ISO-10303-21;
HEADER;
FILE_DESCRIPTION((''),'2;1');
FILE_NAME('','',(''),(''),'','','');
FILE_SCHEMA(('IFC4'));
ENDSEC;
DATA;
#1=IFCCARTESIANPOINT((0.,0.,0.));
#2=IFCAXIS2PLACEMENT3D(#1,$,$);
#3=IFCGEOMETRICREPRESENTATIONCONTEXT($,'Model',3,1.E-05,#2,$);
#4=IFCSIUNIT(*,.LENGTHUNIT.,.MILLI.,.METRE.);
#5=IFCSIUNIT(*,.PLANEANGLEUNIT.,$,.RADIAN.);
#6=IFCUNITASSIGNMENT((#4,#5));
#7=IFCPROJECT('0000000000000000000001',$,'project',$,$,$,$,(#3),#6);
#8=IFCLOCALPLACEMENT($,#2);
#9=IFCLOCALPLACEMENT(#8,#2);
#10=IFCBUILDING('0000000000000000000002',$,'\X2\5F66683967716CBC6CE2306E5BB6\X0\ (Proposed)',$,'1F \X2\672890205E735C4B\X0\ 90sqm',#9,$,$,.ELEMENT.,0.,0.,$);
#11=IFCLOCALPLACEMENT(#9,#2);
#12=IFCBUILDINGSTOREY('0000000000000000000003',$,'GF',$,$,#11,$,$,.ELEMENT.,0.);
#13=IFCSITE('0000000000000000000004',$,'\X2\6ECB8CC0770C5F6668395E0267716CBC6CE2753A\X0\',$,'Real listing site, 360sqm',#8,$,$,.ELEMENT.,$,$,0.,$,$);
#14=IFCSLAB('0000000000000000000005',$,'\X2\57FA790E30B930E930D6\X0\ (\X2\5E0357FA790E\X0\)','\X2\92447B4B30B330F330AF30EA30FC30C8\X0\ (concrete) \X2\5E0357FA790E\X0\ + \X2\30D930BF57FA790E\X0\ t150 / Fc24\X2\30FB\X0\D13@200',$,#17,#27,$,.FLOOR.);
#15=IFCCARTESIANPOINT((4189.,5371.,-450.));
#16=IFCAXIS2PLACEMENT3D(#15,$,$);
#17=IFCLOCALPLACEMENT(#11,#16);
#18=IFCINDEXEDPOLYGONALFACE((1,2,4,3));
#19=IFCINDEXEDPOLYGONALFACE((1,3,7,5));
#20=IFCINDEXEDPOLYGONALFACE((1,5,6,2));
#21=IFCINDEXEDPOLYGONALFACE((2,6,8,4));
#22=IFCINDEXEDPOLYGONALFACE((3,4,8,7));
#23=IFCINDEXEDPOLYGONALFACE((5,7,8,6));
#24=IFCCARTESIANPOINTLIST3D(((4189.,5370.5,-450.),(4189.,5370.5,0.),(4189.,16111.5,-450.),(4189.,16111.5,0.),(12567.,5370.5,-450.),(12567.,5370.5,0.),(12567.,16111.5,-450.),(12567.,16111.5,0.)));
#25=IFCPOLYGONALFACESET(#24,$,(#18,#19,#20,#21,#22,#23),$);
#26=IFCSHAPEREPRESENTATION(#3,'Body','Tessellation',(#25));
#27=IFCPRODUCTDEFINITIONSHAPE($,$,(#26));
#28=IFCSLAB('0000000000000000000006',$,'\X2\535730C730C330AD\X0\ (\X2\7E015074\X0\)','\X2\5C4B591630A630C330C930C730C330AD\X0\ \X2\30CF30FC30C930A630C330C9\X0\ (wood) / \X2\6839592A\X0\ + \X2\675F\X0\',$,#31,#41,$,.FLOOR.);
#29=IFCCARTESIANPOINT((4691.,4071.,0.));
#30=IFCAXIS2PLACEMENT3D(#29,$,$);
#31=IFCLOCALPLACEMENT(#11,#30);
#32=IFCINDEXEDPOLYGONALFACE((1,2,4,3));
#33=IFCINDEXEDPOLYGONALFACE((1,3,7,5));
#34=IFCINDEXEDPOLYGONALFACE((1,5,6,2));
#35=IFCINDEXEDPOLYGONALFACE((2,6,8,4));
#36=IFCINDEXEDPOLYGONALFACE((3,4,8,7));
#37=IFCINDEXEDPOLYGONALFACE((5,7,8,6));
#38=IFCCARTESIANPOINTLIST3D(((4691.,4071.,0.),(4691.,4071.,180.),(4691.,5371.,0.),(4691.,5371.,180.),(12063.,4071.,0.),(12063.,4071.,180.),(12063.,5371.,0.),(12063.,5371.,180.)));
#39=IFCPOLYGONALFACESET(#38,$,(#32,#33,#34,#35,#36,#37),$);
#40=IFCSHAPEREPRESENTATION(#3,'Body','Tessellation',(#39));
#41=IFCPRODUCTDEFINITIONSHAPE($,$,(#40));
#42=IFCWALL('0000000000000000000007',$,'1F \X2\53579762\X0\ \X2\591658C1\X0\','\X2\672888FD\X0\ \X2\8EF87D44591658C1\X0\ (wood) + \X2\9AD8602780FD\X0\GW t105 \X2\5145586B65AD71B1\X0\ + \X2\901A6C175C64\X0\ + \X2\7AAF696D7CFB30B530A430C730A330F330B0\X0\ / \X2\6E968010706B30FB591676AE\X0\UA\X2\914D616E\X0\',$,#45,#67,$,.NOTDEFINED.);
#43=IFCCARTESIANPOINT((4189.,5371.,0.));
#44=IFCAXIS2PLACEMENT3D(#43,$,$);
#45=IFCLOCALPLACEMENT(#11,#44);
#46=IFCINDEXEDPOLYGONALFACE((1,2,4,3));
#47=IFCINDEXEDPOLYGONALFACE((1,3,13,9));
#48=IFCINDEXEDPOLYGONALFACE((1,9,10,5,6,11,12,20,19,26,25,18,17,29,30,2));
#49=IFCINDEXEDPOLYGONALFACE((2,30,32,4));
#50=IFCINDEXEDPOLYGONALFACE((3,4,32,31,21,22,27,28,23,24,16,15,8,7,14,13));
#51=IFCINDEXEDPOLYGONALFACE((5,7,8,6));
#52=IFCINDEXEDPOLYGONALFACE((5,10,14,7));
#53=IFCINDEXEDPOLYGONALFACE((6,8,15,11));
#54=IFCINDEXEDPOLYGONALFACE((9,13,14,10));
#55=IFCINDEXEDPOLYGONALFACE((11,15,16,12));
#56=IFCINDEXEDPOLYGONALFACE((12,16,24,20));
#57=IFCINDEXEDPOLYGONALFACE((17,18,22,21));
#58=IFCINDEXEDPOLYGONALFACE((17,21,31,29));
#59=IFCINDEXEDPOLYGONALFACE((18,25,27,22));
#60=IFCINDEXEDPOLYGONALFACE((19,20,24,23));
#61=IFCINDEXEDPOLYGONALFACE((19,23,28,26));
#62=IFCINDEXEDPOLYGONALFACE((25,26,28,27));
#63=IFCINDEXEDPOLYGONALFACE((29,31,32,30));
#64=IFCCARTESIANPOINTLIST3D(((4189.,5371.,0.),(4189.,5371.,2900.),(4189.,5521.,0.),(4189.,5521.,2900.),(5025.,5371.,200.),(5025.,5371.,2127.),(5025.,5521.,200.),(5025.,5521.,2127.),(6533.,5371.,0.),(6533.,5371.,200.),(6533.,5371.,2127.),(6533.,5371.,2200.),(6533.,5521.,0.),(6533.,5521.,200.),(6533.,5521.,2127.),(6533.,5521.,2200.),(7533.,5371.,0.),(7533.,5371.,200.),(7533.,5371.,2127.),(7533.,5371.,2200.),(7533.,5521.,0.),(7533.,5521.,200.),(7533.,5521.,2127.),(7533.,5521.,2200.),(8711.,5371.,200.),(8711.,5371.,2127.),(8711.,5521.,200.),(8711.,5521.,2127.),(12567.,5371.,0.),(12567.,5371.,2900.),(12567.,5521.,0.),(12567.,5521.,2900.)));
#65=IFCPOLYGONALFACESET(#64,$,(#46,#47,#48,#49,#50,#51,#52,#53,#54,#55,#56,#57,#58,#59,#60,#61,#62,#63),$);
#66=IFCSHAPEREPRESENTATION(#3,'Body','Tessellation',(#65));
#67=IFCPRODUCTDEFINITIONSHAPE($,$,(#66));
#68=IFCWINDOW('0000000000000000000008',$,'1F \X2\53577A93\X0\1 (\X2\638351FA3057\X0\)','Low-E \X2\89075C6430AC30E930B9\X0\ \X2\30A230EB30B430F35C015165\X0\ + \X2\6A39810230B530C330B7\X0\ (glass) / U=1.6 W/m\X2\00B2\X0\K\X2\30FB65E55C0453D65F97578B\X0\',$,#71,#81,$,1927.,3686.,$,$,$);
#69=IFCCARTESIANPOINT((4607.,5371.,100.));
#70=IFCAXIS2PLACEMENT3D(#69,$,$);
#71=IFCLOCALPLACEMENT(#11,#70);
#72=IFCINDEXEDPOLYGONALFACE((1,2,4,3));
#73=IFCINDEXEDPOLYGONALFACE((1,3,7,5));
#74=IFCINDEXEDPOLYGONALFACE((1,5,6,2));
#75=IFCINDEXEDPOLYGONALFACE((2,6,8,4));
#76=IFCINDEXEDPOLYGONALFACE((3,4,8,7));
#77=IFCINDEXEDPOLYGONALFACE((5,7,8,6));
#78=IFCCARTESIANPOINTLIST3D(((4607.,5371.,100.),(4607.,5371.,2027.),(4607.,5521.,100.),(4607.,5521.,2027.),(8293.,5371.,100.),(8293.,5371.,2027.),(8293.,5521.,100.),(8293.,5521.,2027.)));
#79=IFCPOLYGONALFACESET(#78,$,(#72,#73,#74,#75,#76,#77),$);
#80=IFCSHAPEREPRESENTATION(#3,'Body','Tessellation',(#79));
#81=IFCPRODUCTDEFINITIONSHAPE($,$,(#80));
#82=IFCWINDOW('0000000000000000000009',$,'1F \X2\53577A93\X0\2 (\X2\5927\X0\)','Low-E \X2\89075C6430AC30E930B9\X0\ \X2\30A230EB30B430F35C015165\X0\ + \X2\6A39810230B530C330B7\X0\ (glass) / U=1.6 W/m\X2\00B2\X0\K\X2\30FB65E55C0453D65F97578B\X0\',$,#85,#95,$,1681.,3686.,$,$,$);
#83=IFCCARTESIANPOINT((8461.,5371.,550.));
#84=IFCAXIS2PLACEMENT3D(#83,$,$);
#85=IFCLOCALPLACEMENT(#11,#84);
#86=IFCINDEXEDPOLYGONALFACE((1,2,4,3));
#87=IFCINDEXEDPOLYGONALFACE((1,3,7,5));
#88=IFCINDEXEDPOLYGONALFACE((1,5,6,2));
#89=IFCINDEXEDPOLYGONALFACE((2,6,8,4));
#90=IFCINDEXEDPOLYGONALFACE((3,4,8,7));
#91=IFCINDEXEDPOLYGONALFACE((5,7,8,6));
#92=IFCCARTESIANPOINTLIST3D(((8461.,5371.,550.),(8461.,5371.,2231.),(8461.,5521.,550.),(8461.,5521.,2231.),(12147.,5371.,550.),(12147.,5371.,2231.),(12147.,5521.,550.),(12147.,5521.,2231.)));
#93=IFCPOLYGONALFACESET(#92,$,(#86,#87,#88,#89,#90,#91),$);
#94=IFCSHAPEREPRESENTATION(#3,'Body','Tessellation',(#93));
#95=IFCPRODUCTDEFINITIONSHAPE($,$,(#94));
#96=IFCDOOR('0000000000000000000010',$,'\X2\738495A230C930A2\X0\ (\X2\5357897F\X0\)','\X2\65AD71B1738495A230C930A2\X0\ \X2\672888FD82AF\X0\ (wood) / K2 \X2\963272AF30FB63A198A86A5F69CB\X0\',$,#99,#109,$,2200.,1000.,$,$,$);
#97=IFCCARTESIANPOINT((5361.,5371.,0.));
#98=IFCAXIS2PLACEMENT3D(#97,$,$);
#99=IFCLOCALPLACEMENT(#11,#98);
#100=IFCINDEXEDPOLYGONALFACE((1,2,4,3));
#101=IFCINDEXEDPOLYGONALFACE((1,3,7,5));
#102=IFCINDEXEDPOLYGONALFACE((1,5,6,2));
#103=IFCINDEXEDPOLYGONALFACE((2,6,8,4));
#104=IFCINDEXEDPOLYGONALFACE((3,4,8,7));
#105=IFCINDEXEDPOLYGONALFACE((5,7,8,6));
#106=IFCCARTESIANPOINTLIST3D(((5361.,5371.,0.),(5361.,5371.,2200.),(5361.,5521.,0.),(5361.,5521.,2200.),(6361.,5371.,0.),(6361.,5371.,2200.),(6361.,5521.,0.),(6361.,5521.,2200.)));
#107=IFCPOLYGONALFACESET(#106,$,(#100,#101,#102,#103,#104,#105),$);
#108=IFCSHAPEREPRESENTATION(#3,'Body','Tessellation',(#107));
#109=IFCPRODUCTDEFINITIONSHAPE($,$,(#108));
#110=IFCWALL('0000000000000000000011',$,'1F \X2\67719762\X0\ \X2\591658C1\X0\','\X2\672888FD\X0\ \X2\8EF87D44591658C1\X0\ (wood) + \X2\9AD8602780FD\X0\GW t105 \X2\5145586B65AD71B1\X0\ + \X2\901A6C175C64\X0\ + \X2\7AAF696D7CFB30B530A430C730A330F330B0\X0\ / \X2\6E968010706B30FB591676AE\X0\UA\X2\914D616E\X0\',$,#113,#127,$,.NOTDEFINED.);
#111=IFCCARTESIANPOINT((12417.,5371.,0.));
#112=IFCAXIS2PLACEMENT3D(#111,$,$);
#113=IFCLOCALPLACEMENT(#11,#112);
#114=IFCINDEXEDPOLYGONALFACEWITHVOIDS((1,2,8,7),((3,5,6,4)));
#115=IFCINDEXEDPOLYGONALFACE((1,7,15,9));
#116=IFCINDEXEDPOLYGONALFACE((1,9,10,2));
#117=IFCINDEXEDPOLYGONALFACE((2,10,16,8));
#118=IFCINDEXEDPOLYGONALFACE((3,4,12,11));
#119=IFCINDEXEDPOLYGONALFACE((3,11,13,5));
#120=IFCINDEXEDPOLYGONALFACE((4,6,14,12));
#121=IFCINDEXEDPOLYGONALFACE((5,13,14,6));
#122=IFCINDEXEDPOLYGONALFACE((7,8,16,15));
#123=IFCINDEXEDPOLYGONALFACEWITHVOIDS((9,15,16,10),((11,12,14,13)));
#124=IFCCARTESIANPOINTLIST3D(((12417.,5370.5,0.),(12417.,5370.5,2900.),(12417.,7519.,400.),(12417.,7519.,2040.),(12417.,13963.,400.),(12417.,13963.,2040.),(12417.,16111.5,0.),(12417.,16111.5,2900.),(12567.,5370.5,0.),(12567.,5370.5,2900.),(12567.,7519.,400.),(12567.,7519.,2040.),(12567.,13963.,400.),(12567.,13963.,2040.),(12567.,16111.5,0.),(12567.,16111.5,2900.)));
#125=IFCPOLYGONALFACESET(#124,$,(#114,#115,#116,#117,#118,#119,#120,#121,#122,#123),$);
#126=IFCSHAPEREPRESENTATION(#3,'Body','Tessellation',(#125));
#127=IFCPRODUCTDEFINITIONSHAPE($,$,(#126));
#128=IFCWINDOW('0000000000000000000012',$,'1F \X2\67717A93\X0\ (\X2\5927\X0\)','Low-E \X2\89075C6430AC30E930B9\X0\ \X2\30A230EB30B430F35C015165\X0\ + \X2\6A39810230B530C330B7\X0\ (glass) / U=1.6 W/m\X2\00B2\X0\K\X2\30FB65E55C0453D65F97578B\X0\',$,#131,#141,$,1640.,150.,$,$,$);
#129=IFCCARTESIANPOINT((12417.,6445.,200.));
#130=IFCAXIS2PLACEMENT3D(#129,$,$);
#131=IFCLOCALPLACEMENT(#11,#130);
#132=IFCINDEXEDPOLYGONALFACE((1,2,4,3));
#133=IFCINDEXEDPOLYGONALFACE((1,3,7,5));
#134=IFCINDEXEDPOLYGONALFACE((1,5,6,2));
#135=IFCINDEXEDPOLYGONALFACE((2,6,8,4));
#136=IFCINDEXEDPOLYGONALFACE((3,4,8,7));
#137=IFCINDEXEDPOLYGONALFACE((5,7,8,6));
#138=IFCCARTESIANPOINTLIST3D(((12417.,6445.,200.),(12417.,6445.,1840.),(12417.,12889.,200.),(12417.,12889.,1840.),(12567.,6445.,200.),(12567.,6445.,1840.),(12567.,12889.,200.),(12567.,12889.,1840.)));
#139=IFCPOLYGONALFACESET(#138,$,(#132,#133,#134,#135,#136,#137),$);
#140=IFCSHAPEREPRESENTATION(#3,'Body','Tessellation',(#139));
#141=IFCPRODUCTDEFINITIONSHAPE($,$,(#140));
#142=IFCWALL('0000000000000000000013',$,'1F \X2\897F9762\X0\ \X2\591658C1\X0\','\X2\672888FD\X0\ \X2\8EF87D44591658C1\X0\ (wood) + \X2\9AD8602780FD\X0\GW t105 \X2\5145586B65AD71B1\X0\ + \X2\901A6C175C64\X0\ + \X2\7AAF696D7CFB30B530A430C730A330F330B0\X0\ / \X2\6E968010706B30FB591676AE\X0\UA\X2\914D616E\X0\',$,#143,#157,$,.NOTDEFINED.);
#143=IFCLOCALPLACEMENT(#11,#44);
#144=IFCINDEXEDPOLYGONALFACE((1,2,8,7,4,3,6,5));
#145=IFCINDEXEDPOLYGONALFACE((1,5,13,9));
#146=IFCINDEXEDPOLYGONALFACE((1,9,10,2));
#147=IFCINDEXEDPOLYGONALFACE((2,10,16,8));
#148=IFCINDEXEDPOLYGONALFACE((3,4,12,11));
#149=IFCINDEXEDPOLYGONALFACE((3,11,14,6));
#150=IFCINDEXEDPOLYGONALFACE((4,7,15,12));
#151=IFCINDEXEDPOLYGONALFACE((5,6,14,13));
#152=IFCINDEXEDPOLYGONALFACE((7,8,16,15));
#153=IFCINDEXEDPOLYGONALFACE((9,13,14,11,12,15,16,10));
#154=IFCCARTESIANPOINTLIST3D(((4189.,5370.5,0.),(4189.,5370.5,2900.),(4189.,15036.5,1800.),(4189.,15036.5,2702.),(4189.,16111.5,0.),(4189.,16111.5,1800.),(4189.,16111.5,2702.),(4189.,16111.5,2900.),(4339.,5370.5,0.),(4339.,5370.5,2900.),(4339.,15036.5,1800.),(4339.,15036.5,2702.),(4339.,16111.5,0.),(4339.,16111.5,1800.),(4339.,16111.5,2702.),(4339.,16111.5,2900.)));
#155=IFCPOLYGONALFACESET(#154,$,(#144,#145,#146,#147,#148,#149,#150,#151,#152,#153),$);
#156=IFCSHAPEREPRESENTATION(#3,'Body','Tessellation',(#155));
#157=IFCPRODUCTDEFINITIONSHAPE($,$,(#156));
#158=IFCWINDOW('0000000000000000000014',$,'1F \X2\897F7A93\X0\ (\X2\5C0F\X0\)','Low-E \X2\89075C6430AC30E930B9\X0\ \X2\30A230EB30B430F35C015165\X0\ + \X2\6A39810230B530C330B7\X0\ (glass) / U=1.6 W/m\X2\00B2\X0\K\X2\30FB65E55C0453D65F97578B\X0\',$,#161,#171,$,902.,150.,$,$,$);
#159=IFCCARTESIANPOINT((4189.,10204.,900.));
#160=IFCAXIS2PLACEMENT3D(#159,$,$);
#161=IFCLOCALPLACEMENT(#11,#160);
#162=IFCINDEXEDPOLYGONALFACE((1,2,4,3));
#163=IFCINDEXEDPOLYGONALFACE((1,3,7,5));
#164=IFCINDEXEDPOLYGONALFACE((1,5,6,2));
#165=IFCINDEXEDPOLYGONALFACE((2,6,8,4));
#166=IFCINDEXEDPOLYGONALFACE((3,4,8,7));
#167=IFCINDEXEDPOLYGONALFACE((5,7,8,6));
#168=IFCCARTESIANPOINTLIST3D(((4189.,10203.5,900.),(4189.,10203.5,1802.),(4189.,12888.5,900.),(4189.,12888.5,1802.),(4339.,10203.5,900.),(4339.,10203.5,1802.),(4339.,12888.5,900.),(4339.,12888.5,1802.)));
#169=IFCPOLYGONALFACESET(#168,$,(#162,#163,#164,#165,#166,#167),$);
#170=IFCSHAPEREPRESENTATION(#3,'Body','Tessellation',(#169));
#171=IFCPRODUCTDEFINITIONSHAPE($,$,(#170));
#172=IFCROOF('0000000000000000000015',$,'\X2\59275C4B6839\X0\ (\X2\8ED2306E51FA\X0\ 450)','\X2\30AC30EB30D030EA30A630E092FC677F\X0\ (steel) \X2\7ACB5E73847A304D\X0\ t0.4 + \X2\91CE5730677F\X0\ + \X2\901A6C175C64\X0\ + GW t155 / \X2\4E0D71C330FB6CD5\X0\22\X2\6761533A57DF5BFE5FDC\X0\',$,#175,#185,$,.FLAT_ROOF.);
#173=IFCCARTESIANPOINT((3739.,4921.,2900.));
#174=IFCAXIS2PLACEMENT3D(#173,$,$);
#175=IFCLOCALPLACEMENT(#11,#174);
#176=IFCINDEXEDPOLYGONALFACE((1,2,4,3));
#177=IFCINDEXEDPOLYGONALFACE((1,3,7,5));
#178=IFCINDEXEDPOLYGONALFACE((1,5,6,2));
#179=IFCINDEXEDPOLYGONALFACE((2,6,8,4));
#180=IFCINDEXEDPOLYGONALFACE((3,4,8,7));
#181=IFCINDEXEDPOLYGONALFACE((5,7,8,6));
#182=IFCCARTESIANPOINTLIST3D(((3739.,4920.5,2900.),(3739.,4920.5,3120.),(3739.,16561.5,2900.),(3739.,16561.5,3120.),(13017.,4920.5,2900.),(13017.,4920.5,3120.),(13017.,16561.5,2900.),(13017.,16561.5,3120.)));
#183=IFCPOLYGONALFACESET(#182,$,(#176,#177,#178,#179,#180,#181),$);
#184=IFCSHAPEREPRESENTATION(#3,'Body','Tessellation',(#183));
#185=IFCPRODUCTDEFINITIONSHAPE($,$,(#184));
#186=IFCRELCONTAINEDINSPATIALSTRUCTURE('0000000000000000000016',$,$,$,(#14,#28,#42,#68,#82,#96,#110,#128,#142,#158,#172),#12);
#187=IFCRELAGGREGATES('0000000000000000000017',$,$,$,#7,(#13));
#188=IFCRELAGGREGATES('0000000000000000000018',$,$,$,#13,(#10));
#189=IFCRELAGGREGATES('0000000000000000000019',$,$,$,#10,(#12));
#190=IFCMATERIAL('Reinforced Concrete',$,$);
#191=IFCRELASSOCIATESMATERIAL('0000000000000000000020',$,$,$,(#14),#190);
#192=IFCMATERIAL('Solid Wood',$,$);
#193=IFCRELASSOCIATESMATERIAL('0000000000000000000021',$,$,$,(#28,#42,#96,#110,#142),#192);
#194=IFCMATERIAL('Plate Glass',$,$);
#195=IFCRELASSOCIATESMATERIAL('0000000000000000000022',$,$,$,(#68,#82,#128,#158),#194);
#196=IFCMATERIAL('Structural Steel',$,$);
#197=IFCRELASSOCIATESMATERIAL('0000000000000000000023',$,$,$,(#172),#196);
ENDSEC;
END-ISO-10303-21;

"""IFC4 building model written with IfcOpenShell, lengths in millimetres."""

from ifc_helpers import new_model, si_unit, frame, frame_2d, origin, place, context, project, spatial, rectangle, extrude, material, element, fill, save


model = new_model("IFC4")

# Units and contexts
model_context = context("Model", 3, precision=1e-05, world=origin())
ifc_project = project(units=[si_unit("LENGTHUNIT", "METRE", prefix="MILLI"), si_unit("PLANEANGLEUNIT", "RADIAN")], contexts=[model_context])

# Site, building, storey
site_placement = place(None, origin())
site = spatial("IfcSite", under=ifc_project, at=site_placement, Name="滋賀県彦根市東沼波町", ObjectType="Real listing site, 360sqm", CompositionType="ELEMENT", RefElevation=0.0)
building_placement = place(site_placement, origin())
building = spatial("IfcBuilding", under=site, at=building_placement, Name="彦根東沼波の家 (Proposed)", ObjectType="1F 木造平屋 90sqm", CompositionType="ELEMENT", ElevationOfRefHeight=0.0, ElevationOfTerrain=0.0)
storey_placement = place(building_placement, origin())
storey = spatial("IfcBuildingStorey", under=building, at=storey_placement, Name="GF", CompositionType="ELEMENT", Elevation=0.0)

# Slabs
ifc_material_1 = material(Name="Reinforced Concrete")
slab_1_placement = place(storey_placement, frame((4189.0, 5371.0, -450.0)))
element("IfcSlab", 1, at=slab_1_placement, inside=storey, material=ifc_material_1, Name="基礎スラブ (布基礎)", Description="鉄筋コンクリート (concrete) 布基礎 + ベタ基礎 t150 / Fc24・D13@200", PredefinedType="FLOOR", context=model_context, shape_type="SweptSolid", body=[
    extrude(rectangle(XDim=8378.0, YDim=10741.0, at=frame_2d((4189.0, 5370.0))), frame((4189.0, 5371.0, -450.0)), (0.0, 0.0, 1.0), 450.0),
])
ifc_material_2 = material(Name="Solid Wood")
slab_2_placement = place(storey_placement, frame((4691.0, 4071.0, 0.0)))
element("IfcSlab", 2, at=slab_2_placement, inside=storey, material=ifc_material_2, Name="南デッキ (縁側)", Description="屋外ウッドデッキ ハードウッド (wood) / 根太 + 束", PredefinedType="FLOOR", context=model_context, shape_type="SweptSolid", body=[
    extrude(rectangle(XDim=7372.0, YDim=1300.0, at=frame_2d((3686.0, 650.0))), frame((4691.0, 4071.0, 0.0)), (0.0, 0.0, 1.0), 180.0),
])

# Wall, openings, windows, door
wall_1_placement = place(storey_placement, frame((4189.0, 5371.0, 0.0)))
wall_1 = element("IfcWall", 3, at=wall_1_placement, inside=storey, material=ifc_material_2, Name="1F 南面 外壁", Description="木製 軸組外壁 (wood) + 高性能GW t105 充填断熱 + 通気層 + 窯業系サイディング / 準耐火・外皮UA配慮", PredefinedType="NOTDEFINED", context=model_context, shape_type="SweptSolid", body=[
    extrude(rectangle(XDim=8378.0, YDim=150.0, at=frame_2d((4189.0, 75.0))), frame((4189.0, 5371.0, 0.0)), (0.0, 0.0, 1.0), 2900.0),
])
opening_1_placement = place(storey_placement, frame((4607.0, 5371.0, 100.0)))
opening_1 = element("IfcOpeningElement", 4, at=opening_1_placement, cuts=wall_1, PredefinedType="NOTDEFINED", context=model_context, shape_type="SweptSolid", body=[
    extrude(rectangle(XDim=3686.0, YDim=150.0, at=frame_2d((1843.0, 75.0))), frame((4607.0, 5371.0, 100.0)), (0.0, 0.0, 1.0), 1927.0),
])
opening_2_placement = place(storey_placement, frame((8461.0, 5371.0, 550.0)))
opening_2 = element("IfcOpeningElement", 5, at=opening_2_placement, cuts=wall_1, PredefinedType="NOTDEFINED", context=model_context, shape_type="SweptSolid", body=[
    extrude(rectangle(XDim=3686.0, YDim=150.0, at=frame_2d((1843.0, 75.0))), frame((8461.0, 5371.0, 550.0)), (0.0, 0.0, 1.0), 1681.0),
])
opening_3_placement = place(storey_placement, frame((5361.0, 5371.0, 0.0)))
opening_3 = element("IfcOpeningElement", 6, at=opening_3_placement, cuts=wall_1, PredefinedType="NOTDEFINED", context=model_context, shape_type="SweptSolid", body=[
    extrude(rectangle(XDim=1000.0, YDim=150.0, at=frame_2d((500.0, 75.0))), frame((5361.0, 5371.0, 0.0)), (0.0, 0.0, 1.0), 2200.0),
])
ifc_material_3 = material(Name="Plate Glass")
window_1_placement = place(storey_placement, frame((4607.0, 5371.0, 100.0)))
window_1 = element("IfcWindow", 7, at=window_1_placement, inside=storey, material=ifc_material_3, Name="1F 南窓1 (掃出し)", Description="Low-E 複層ガラス アルゴン封入 + 樹脂サッシ (glass) / U=1.6 W/m²K・日射取得型", OverallHeight=1927.0, OverallWidth=3686.0, context=model_context, shape_type="SweptSolid", body=[
    extrude(rectangle(XDim=3686.0, YDim=150.0, at=frame_2d((1843.0, 75.0))), frame((4607.0, 5371.0, 100.0)), (0.0, 0.0, 1.0), 1927.0),
])
fill(opening_1, window_1)
window_2_placement = place(storey_placement, frame((8461.0, 5371.0, 550.0)))
window_2 = element("IfcWindow", 8, at=window_2_placement, inside=storey, material=ifc_material_3, Name="1F 南窓2 (大)", Description="Low-E 複層ガラス アルゴン封入 + 樹脂サッシ (glass) / U=1.6 W/m²K・日射取得型", OverallHeight=1681.0, OverallWidth=3686.0, context=model_context, shape_type="SweptSolid", body=[
    extrude(rectangle(XDim=3686.0, YDim=150.0, at=frame_2d((1843.0, 75.0))), frame((8461.0, 5371.0, 550.0)), (0.0, 0.0, 1.0), 1681.0),
])
fill(opening_2, window_2)
door_placement = place(storey_placement, frame((5361.0, 5371.0, 0.0)))
door = element("IfcDoor", 9, at=door_placement, inside=storey, material=ifc_material_2, Name="玄関ドア (南西)", Description="断熱玄関ドア 木製芯 (wood) / K2 防犯・採風機構", OverallHeight=2200.0, OverallWidth=1000.0, context=model_context, shape_type="SweptSolid", body=[
    extrude(rectangle(XDim=1000.0, YDim=150.0, at=frame_2d((500.0, 75.0))), frame((5361.0, 5371.0, 0.0)), (0.0, 0.0, 1.0), 2200.0),
])
fill(opening_3, door)

# Walls, openings, windows
wall_2_placement = place(storey_placement, frame((12417.0, 5371.0, 0.0)))
wall_2 = element("IfcWall", 10, at=wall_2_placement, inside=storey, material=ifc_material_2, Name="1F 東面 外壁", Description="木製 軸組外壁 (wood) + 高性能GW t105 充填断熱 + 通気層 + 窯業系サイディング / 準耐火・外皮UA配慮", PredefinedType="NOTDEFINED", context=model_context, shape_type="SweptSolid", body=[
    extrude(rectangle(XDim=150.0, YDim=10741.0, at=frame_2d((75.0, 5370.0))), frame((12417.0, 5371.0, 0.0)), (0.0, 0.0, 1.0), 2900.0),
])
opening_4_placement = place(storey_placement, frame((12417.0, 6445.0, 200.0)))
opening_4 = element("IfcOpeningElement", 11, at=opening_4_placement, cuts=wall_2, PredefinedType="NOTDEFINED", context=model_context, shape_type="SweptSolid", body=[
    extrude(rectangle(XDim=150.0, YDim=6444.0, at=frame_2d((75.0, 3222.0))), frame((12417.0, 6445.0, 200.0)), (0.0, 0.0, 1.0), 1640.0),
])
window_3_placement = place(storey_placement, frame((12417.0, 6445.0, 200.0)))
window_3 = element("IfcWindow", 12, at=window_3_placement, inside=storey, material=ifc_material_3, Name="1F 東窓 (大)", Description="Low-E 複層ガラス アルゴン封入 + 樹脂サッシ (glass) / U=1.6 W/m²K・日射取得型", OverallHeight=1640.0, OverallWidth=150.0, context=model_context, shape_type="SweptSolid", body=[
    extrude(rectangle(XDim=150.0, YDim=6444.0, at=frame_2d((75.0, 3222.0))), frame((12417.0, 6445.0, 200.0)), (0.0, 0.0, 1.0), 1640.0),
])
fill(opening_4, window_3)
wall_3_placement = place(storey_placement, frame((4189.0, 5371.0, 0.0)))
wall_3 = element("IfcWall", 13, at=wall_3_placement, inside=storey, material=ifc_material_2, Name="1F 西面 外壁", Description="木製 軸組外壁 (wood) + 高性能GW t105 充填断熱 + 通気層 + 窯業系サイディング / 準耐火・外皮UA配慮", PredefinedType="NOTDEFINED", context=model_context, shape_type="SweptSolid", body=[
    extrude(rectangle(XDim=150.0, YDim=10741.0, at=frame_2d((75.0, 5370.0))), frame((4189.0, 5371.0, 0.0)), (0.0, 0.0, 1.0), 2900.0),
])
opening_5_placement = place(storey_placement, frame((4189.0, 10204.0, 900.0)))
opening_5 = element("IfcOpeningElement", 14, at=opening_5_placement, cuts=wall_3, PredefinedType="NOTDEFINED", context=model_context, shape_type="SweptSolid", body=[
    extrude(rectangle(XDim=150.0, YDim=2685.0, at=frame_2d((75.0, 1342.0))), frame((4189.0, 10204.0, 900.0)), (0.0, 0.0, 1.0), 902.0),
])
window_4_placement = place(storey_placement, frame((4189.0, 10204.0, 900.0)))
window_4 = element("IfcWindow", 15, at=window_4_placement, inside=storey, material=ifc_material_3, Name="1F 西窓 (小)", Description="Low-E 複層ガラス アルゴン封入 + 樹脂サッシ (glass) / U=1.6 W/m²K・日射取得型", OverallHeight=902.0, OverallWidth=150.0, context=model_context, shape_type="SweptSolid", body=[
    extrude(rectangle(XDim=150.0, YDim=2685.0, at=frame_2d((75.0, 1342.0))), frame((4189.0, 10204.0, 900.0)), (0.0, 0.0, 1.0), 902.0),
])
fill(opening_5, window_4)

# Roof
ifc_material_4 = material(Name="Structural Steel")
roof_placement = place(storey_placement, frame((3739.0, 4921.0, 2900.0)))
element("IfcRoof", 16, at=roof_placement, inside=storey, material=ifc_material_4, Name="大屋根 (軒の出 450)", Description="ガルバリウム鋼板 (steel) 立平葺き t0.4 + 野地板 + 通気層 + GW t155 / 不燃・法22条区域対応", PredefinedType="FLAT_ROOF", context=model_context, shape_type="SweptSolid", body=[
    extrude(rectangle(XDim=9278.0, YDim=11641.0, at=frame_2d((4639.0, 5820.0))), frame((3739.0, 4921.0, 2900.0)), (0.0, 0.0, 1.0), 220.0),
])

save(model, "model.ifc")
